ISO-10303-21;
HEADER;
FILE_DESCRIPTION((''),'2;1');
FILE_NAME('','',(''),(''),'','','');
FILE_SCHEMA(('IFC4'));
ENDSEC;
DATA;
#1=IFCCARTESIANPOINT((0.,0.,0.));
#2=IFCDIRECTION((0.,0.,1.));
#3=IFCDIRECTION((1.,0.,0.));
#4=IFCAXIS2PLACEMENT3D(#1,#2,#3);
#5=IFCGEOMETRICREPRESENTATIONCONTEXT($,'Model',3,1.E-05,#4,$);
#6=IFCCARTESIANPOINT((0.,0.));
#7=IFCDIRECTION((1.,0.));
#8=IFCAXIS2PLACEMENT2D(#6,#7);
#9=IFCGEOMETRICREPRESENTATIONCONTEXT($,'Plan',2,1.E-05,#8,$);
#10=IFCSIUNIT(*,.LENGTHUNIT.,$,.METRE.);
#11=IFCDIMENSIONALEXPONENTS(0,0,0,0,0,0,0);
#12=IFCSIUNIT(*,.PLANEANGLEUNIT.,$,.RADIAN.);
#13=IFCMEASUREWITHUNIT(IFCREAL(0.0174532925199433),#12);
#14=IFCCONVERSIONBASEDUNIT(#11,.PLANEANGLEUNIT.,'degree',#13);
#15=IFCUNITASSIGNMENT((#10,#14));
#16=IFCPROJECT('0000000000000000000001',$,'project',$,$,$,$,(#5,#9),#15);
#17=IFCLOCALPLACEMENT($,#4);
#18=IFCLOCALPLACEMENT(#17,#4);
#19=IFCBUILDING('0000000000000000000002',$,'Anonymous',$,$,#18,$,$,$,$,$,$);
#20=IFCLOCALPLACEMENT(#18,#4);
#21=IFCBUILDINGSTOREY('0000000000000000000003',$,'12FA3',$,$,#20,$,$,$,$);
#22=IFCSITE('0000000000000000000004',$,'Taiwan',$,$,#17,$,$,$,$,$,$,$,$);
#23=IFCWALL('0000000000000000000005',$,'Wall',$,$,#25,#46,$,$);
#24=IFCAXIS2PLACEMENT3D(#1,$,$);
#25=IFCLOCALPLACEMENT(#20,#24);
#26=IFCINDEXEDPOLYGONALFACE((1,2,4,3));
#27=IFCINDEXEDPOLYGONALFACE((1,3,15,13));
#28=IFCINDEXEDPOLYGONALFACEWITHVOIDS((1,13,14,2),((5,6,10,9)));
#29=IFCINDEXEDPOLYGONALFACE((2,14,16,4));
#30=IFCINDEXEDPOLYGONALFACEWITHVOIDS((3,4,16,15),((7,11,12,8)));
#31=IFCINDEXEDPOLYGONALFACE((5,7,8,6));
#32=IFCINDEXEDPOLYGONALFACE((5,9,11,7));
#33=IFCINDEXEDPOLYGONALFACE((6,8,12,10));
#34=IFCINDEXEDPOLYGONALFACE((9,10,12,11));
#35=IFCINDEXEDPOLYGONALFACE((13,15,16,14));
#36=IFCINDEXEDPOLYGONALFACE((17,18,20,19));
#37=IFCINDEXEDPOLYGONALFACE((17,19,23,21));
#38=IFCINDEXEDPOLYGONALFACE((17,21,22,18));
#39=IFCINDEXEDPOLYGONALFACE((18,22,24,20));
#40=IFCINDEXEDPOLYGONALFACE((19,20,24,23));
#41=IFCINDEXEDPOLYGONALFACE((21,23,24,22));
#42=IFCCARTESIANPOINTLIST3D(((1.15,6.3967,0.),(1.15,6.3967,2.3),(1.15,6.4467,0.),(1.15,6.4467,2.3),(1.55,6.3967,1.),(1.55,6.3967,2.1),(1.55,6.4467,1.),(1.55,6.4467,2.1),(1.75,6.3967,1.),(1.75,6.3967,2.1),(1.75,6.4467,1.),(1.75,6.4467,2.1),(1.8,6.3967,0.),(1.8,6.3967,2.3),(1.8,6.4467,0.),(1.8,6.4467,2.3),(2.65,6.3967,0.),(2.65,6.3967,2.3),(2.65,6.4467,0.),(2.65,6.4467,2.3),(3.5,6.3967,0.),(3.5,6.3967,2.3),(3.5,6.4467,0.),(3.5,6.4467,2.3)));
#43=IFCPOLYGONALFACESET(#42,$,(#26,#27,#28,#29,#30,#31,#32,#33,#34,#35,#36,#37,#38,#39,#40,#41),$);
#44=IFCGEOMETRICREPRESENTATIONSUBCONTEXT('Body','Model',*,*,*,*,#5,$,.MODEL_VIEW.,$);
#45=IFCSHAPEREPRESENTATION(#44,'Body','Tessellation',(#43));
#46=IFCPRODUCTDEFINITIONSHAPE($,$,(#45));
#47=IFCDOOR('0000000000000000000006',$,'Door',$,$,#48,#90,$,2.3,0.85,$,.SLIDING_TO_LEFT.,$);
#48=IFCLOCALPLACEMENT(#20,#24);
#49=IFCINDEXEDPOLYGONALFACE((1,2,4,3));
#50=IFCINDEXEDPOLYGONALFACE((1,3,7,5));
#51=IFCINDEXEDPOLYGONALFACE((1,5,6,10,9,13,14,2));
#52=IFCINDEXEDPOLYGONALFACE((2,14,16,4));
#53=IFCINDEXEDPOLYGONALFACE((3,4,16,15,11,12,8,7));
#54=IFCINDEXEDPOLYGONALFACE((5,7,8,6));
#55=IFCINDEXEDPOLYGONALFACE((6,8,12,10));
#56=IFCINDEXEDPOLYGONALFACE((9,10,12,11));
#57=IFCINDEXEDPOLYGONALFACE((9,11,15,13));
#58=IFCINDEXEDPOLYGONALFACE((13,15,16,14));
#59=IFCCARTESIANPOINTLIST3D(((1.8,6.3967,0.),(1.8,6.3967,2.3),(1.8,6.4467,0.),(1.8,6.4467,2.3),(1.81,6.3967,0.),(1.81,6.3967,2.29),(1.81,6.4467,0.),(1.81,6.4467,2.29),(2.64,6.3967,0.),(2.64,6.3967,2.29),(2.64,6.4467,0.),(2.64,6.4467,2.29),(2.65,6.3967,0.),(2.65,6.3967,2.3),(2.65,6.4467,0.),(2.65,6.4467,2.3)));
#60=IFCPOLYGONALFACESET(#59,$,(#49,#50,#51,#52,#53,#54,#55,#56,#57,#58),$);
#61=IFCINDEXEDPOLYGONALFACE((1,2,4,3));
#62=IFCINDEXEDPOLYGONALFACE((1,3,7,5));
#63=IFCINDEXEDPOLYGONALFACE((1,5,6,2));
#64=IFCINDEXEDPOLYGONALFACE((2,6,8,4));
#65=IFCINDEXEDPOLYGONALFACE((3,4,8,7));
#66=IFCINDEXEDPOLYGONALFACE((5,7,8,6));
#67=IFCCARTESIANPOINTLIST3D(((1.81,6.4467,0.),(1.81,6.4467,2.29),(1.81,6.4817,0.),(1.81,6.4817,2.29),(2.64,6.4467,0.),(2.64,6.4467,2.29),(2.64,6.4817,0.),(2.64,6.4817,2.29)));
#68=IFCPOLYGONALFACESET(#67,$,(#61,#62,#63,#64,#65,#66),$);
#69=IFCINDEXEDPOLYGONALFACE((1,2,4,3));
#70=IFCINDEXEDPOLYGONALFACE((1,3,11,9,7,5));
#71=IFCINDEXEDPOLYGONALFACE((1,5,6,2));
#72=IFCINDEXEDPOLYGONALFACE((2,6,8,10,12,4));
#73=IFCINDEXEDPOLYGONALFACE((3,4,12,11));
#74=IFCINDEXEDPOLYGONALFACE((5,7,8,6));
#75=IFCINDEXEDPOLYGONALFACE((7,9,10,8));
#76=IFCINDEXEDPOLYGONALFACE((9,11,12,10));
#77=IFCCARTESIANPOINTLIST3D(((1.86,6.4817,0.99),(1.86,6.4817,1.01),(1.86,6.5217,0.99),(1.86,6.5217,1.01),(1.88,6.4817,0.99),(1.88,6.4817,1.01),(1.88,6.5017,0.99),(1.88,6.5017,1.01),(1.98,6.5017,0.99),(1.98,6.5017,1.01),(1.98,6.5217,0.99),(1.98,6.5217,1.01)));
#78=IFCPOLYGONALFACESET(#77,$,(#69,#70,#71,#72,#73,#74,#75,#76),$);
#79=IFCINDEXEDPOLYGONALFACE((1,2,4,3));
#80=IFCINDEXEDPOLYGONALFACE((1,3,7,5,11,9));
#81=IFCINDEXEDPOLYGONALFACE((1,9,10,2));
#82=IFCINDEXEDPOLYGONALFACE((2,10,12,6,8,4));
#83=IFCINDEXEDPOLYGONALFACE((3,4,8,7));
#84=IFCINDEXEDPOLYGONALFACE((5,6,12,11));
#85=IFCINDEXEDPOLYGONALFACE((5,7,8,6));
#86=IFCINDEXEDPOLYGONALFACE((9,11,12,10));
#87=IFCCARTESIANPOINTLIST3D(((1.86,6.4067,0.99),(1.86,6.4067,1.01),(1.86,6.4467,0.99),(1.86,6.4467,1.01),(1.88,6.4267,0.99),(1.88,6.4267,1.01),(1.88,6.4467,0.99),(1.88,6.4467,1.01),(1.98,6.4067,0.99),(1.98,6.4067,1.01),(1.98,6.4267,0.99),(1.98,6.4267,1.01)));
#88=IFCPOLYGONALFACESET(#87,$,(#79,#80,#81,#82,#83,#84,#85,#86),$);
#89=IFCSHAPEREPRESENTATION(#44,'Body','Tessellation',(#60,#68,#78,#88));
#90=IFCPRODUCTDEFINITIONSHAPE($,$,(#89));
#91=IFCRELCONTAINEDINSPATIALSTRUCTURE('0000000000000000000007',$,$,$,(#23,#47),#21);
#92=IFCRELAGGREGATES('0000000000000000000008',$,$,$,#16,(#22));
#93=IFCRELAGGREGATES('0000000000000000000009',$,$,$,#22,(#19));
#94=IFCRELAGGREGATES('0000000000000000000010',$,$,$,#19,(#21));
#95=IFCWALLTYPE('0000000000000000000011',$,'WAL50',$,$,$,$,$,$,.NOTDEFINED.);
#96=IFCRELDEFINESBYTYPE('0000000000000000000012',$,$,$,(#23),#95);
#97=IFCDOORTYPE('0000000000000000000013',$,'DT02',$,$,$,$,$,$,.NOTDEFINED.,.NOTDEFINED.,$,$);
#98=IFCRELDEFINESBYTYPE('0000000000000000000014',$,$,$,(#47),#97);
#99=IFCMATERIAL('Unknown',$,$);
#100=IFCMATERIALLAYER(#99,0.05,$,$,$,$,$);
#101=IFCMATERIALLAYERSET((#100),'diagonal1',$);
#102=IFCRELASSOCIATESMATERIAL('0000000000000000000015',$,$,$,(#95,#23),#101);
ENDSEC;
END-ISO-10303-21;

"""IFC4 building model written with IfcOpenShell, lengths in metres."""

from ifc_helpers import new_model, entity, si_unit, converted_unit, frame, origin_with_axes, origin_2d_with_axis, place, context, subcontext, project, spatial, line, indexed_curve, outline, extrude, shape, source, transform, mapped, material, layer, layer_set, layer_usage, type_object, type_shapes, element, fill, save


model = new_model("IFC4")

# Units and contexts
model_context = context("Model", 3, precision=1e-05, world=origin_with_axes())
plan_context = context("Plan", 2, precision=1e-05, world=origin_2d_with_axis())
body_context_1 = subcontext(model_context, "Body", "Model", "MODEL_VIEW")
body_context_2 = subcontext(plan_context, "Body", "Plan", "PLAN_VIEW")
ifc_project = project(units=[si_unit("LENGTHUNIT", "METRE"), converted_unit("PLANEANGLEUNIT", "degree", entity("IfcReal", 0.0174532925199433), si_unit("PLANEANGLEUNIT", "RADIAN"), dimensions=[0, 0, 0, 0, 0, 0, 0])], contexts=[model_context, plan_context])

# Site, building, storey
site_placement = place(None, origin_with_axes())
site = spatial("IfcSite", under=ifc_project, at=site_placement, Name="Taiwan")
building_placement = place(site_placement, origin_with_axes())
building = spatial("IfcBuilding", under=site, at=building_placement, Name="Anonymous")
storey_placement = place(building_placement, origin_with_axes())
storey = spatial("IfcBuildingStorey", under=building, at=storey_placement, Name="12FA3")

# Shared definitions
ifc_material = material(Name="Unknown")

# Wall, openings, door
ifc_layer_1 = layer(ifc_material, 0.05)
ifc_layer_set_1 = layer_set([ifc_layer_1], Name="diagonal1")
ifc_layer_usage_1 = layer_usage(ifc_layer_set_1, "AXIS2", "POSITIVE", 0.0)
wall_type_1 = type_object("IfcWallType", Name="WAL50", PredefinedType="NOTDEFINED", material=ifc_layer_set_1)
wall_1_placement = place(storey_placement, frame((3.5, 6.4467, 0.0), z_axis=(0.0, 0.0, 1.0), x_axis=(-1.0, 0.0, 0.0)))
wall_1 = element("IfcWall", 1, at=wall_1_placement, inside=storey, type_object=wall_type_1, material=ifc_layer_usage_1, Name="Wall", context=body_context_1, shape_type="SweptSolid", body=[
    extrude(outline(indexed_curve([(0.0, 0.0), (0.0, 0.05), (2.35, 0.05), (2.35, 0.0)], segments=[line(1, 2, 3, 4, 1)])), origin_with_axes(), (0.0, 0.0, 1.0), 2.3),
])
shared_shape_1 = source(origin_with_axes(), body_context_1, "Body", "SweptSolid", [
    extrude(outline(indexed_curve([(0.0, 0.0), (0.85, 0.0), (0.85, 2.3), (0.0, 2.3)], segments=[line(1, 2, 3, 4, 1)])), frame((0.0, -0.6, 0.0), z_axis=(0.0, -1.0, 0.0), x_axis=(1.0, 0.0, 0.0)), (0.0, 0.0, -1.0), 1.2),
])
opening_1_placement = place(wall_1_placement, frame((0.85, 0.0, 0.0), z_axis=(0.0, 0.0, 1.0), x_axis=(1.0, 0.0, 0.0)))
opening_1 = element("IfcOpeningElement", 2, at=opening_1_placement, cuts=wall_1, PredefinedType="OPENING", context=body_context_1, shape_type="MappedRepresentation", body=[
    mapped(shared_shape_1, transform((0.0, 0.0, 0.0), x_axis=(1.0, 0.0, 0.0), y_axis=(0.0, 1.0, 0.0), z_axis=(0.0, 0.0, 1.0), scale=1.0)),
])
opening_2_placement = place(wall_1_placement, frame((1.95, 0.25, 1.0), z_axis=(0.0, 0.0, 1.0), x_axis=(-1.0, 0.0, 0.0)))
element("IfcOpeningElement", 3, at=opening_2_placement, cuts=wall_1, PredefinedType="OPENING", context=body_context_1, shape_type="SweptSolid", body=[
    extrude(outline(indexed_curve([(0.0, 0.0), (0.2, 0.0), (0.2, 0.5), (0.0, 0.5), (0.0, 0.0)])), origin_with_axes(), (0.0, 0.0, 1.0), 1.1),
])
door_type_1 = type_object("IfcDoorType", Name="DT02", OperationType="NOTDEFINED", PredefinedType="NOTDEFINED")
shared_shape_2 = source(origin_with_axes(), body_context_1, "Body", "SweptSolid", [
    extrude(outline(indexed_curve([(0.0, 0.0), (0.0, 2.3), (0.85, 2.3), (0.85, 0.0), (0.84, 0.0), (0.84, 2.29), (0.01, 2.29), (0.01, 0.0)], segments=[line(1, 2, 3, 4, 5, 6, 7, 8, 1)])), frame((0.0, 0.0, 0.0), z_axis=(0.0, -1.0, 0.0), x_axis=(1.0, 0.0, 0.0)), (0.0, 0.0, -1.0), 0.05),
    extrude(outline(indexed_curve([(0.0, 0.0), (0.83, 0.0), (0.83, 0.035), (0.0, 0.035)], segments=[line(1, 2, 3, 4, 1)])), frame((0.01, -0.035, 0.0), z_axis=(0.0, 0.0, 1.0), x_axis=(1.0, 0.0, 0.0)), (0.0, 0.0, 1.0), 2.29),
    extrude(outline(indexed_curve([(0.0, 0.0), (0.0, -0.04), (-0.12, -0.04), (-0.12, -0.02), (-0.02, -0.02), (-0.02, 0.0)], segments=[line(1, 2, 3, 4, 5, 6, 1)])), frame((0.79, -0.035, 0.99), z_axis=(0.0, 0.0, 1.0), x_axis=(1.0, 0.0, 0.0)), (0.0, 0.0, 1.0), 0.02),
    extrude(outline(indexed_curve([(0.0, 0.0), (0.0, 0.04), (-0.12, 0.04), (-0.12, 0.02), (-0.02, 0.02), (-0.02, 0.0)], segments=[line(1, 2, 3, 4, 5, 6, 1)])), frame((0.79, 0.0, 0.99), z_axis=(0.0, 0.0, 1.0), x_axis=(1.0, 0.0, 0.0)), (0.0, 0.0, 1.0), 0.02),
])
shared_shape_3 = source(origin_with_axes(), body_context_2, "Body", "Curve2D", [
    entity("IfcIndexedPolyCurve", entity("IfcCartesianPointList2D", [[0.0, 0.0], [0.01, 0.0], [0.01, 0.05], [0.0, 0.05]]), [entity("IfcLineIndex", [1, 2, 3, 4, 1])]),
    entity("IfcIndexedPolyCurve", entity("IfcCartesianPointList2D", [[0.85, 0.0], [0.84, 0.0], [0.84, 0.05], [0.85, 0.05]]), [entity("IfcLineIndex", [1, 2, 3, 4, 1])]),
    entity("IfcIndexedPolyCurve", entity("IfcCartesianPointList2D", [[-0.405, -0.035], [0.425, -0.035], [0.425, 0.0], [-0.405, 0.0]]), [entity("IfcLineIndex", [1, 2, 3, 4, 1])]),
])
type_shapes(door_type_1, [shared_shape_2, shared_shape_3])
door_1_placement = place(opening_1_placement, origin_with_axes())
door_1 = element("IfcDoor", 4, at=door_1_placement, inside=storey, type_object=door_type_1, Name="Door", OperationType="SLIDING_TO_LEFT", OverallHeight=2.3, OverallWidth=0.85, shapes=[
    shape(body_context_1, "Body", "MappedRepresentation", [mapped(shared_shape_2, transform((0.0, 0.0, 0.0), x_axis=(1.0, 0.0, 0.0), y_axis=(0.0, 1.0, 0.0), z_axis=(0.0, 0.0, 1.0), scale=1.0))]),
    shape(body_context_2, "Body", "MappedRepresentation", [mapped(shared_shape_3, transform((0.0, 0.0, 0.0), x_axis=(1.0, 0.0, 0.0), y_axis=(0.0, 1.0, 0.0), z_axis=(0.0, 0.0, 1.0), scale=1.0))]),
])
fill(opening_1, door_1)

save(model, "model.ifc")
